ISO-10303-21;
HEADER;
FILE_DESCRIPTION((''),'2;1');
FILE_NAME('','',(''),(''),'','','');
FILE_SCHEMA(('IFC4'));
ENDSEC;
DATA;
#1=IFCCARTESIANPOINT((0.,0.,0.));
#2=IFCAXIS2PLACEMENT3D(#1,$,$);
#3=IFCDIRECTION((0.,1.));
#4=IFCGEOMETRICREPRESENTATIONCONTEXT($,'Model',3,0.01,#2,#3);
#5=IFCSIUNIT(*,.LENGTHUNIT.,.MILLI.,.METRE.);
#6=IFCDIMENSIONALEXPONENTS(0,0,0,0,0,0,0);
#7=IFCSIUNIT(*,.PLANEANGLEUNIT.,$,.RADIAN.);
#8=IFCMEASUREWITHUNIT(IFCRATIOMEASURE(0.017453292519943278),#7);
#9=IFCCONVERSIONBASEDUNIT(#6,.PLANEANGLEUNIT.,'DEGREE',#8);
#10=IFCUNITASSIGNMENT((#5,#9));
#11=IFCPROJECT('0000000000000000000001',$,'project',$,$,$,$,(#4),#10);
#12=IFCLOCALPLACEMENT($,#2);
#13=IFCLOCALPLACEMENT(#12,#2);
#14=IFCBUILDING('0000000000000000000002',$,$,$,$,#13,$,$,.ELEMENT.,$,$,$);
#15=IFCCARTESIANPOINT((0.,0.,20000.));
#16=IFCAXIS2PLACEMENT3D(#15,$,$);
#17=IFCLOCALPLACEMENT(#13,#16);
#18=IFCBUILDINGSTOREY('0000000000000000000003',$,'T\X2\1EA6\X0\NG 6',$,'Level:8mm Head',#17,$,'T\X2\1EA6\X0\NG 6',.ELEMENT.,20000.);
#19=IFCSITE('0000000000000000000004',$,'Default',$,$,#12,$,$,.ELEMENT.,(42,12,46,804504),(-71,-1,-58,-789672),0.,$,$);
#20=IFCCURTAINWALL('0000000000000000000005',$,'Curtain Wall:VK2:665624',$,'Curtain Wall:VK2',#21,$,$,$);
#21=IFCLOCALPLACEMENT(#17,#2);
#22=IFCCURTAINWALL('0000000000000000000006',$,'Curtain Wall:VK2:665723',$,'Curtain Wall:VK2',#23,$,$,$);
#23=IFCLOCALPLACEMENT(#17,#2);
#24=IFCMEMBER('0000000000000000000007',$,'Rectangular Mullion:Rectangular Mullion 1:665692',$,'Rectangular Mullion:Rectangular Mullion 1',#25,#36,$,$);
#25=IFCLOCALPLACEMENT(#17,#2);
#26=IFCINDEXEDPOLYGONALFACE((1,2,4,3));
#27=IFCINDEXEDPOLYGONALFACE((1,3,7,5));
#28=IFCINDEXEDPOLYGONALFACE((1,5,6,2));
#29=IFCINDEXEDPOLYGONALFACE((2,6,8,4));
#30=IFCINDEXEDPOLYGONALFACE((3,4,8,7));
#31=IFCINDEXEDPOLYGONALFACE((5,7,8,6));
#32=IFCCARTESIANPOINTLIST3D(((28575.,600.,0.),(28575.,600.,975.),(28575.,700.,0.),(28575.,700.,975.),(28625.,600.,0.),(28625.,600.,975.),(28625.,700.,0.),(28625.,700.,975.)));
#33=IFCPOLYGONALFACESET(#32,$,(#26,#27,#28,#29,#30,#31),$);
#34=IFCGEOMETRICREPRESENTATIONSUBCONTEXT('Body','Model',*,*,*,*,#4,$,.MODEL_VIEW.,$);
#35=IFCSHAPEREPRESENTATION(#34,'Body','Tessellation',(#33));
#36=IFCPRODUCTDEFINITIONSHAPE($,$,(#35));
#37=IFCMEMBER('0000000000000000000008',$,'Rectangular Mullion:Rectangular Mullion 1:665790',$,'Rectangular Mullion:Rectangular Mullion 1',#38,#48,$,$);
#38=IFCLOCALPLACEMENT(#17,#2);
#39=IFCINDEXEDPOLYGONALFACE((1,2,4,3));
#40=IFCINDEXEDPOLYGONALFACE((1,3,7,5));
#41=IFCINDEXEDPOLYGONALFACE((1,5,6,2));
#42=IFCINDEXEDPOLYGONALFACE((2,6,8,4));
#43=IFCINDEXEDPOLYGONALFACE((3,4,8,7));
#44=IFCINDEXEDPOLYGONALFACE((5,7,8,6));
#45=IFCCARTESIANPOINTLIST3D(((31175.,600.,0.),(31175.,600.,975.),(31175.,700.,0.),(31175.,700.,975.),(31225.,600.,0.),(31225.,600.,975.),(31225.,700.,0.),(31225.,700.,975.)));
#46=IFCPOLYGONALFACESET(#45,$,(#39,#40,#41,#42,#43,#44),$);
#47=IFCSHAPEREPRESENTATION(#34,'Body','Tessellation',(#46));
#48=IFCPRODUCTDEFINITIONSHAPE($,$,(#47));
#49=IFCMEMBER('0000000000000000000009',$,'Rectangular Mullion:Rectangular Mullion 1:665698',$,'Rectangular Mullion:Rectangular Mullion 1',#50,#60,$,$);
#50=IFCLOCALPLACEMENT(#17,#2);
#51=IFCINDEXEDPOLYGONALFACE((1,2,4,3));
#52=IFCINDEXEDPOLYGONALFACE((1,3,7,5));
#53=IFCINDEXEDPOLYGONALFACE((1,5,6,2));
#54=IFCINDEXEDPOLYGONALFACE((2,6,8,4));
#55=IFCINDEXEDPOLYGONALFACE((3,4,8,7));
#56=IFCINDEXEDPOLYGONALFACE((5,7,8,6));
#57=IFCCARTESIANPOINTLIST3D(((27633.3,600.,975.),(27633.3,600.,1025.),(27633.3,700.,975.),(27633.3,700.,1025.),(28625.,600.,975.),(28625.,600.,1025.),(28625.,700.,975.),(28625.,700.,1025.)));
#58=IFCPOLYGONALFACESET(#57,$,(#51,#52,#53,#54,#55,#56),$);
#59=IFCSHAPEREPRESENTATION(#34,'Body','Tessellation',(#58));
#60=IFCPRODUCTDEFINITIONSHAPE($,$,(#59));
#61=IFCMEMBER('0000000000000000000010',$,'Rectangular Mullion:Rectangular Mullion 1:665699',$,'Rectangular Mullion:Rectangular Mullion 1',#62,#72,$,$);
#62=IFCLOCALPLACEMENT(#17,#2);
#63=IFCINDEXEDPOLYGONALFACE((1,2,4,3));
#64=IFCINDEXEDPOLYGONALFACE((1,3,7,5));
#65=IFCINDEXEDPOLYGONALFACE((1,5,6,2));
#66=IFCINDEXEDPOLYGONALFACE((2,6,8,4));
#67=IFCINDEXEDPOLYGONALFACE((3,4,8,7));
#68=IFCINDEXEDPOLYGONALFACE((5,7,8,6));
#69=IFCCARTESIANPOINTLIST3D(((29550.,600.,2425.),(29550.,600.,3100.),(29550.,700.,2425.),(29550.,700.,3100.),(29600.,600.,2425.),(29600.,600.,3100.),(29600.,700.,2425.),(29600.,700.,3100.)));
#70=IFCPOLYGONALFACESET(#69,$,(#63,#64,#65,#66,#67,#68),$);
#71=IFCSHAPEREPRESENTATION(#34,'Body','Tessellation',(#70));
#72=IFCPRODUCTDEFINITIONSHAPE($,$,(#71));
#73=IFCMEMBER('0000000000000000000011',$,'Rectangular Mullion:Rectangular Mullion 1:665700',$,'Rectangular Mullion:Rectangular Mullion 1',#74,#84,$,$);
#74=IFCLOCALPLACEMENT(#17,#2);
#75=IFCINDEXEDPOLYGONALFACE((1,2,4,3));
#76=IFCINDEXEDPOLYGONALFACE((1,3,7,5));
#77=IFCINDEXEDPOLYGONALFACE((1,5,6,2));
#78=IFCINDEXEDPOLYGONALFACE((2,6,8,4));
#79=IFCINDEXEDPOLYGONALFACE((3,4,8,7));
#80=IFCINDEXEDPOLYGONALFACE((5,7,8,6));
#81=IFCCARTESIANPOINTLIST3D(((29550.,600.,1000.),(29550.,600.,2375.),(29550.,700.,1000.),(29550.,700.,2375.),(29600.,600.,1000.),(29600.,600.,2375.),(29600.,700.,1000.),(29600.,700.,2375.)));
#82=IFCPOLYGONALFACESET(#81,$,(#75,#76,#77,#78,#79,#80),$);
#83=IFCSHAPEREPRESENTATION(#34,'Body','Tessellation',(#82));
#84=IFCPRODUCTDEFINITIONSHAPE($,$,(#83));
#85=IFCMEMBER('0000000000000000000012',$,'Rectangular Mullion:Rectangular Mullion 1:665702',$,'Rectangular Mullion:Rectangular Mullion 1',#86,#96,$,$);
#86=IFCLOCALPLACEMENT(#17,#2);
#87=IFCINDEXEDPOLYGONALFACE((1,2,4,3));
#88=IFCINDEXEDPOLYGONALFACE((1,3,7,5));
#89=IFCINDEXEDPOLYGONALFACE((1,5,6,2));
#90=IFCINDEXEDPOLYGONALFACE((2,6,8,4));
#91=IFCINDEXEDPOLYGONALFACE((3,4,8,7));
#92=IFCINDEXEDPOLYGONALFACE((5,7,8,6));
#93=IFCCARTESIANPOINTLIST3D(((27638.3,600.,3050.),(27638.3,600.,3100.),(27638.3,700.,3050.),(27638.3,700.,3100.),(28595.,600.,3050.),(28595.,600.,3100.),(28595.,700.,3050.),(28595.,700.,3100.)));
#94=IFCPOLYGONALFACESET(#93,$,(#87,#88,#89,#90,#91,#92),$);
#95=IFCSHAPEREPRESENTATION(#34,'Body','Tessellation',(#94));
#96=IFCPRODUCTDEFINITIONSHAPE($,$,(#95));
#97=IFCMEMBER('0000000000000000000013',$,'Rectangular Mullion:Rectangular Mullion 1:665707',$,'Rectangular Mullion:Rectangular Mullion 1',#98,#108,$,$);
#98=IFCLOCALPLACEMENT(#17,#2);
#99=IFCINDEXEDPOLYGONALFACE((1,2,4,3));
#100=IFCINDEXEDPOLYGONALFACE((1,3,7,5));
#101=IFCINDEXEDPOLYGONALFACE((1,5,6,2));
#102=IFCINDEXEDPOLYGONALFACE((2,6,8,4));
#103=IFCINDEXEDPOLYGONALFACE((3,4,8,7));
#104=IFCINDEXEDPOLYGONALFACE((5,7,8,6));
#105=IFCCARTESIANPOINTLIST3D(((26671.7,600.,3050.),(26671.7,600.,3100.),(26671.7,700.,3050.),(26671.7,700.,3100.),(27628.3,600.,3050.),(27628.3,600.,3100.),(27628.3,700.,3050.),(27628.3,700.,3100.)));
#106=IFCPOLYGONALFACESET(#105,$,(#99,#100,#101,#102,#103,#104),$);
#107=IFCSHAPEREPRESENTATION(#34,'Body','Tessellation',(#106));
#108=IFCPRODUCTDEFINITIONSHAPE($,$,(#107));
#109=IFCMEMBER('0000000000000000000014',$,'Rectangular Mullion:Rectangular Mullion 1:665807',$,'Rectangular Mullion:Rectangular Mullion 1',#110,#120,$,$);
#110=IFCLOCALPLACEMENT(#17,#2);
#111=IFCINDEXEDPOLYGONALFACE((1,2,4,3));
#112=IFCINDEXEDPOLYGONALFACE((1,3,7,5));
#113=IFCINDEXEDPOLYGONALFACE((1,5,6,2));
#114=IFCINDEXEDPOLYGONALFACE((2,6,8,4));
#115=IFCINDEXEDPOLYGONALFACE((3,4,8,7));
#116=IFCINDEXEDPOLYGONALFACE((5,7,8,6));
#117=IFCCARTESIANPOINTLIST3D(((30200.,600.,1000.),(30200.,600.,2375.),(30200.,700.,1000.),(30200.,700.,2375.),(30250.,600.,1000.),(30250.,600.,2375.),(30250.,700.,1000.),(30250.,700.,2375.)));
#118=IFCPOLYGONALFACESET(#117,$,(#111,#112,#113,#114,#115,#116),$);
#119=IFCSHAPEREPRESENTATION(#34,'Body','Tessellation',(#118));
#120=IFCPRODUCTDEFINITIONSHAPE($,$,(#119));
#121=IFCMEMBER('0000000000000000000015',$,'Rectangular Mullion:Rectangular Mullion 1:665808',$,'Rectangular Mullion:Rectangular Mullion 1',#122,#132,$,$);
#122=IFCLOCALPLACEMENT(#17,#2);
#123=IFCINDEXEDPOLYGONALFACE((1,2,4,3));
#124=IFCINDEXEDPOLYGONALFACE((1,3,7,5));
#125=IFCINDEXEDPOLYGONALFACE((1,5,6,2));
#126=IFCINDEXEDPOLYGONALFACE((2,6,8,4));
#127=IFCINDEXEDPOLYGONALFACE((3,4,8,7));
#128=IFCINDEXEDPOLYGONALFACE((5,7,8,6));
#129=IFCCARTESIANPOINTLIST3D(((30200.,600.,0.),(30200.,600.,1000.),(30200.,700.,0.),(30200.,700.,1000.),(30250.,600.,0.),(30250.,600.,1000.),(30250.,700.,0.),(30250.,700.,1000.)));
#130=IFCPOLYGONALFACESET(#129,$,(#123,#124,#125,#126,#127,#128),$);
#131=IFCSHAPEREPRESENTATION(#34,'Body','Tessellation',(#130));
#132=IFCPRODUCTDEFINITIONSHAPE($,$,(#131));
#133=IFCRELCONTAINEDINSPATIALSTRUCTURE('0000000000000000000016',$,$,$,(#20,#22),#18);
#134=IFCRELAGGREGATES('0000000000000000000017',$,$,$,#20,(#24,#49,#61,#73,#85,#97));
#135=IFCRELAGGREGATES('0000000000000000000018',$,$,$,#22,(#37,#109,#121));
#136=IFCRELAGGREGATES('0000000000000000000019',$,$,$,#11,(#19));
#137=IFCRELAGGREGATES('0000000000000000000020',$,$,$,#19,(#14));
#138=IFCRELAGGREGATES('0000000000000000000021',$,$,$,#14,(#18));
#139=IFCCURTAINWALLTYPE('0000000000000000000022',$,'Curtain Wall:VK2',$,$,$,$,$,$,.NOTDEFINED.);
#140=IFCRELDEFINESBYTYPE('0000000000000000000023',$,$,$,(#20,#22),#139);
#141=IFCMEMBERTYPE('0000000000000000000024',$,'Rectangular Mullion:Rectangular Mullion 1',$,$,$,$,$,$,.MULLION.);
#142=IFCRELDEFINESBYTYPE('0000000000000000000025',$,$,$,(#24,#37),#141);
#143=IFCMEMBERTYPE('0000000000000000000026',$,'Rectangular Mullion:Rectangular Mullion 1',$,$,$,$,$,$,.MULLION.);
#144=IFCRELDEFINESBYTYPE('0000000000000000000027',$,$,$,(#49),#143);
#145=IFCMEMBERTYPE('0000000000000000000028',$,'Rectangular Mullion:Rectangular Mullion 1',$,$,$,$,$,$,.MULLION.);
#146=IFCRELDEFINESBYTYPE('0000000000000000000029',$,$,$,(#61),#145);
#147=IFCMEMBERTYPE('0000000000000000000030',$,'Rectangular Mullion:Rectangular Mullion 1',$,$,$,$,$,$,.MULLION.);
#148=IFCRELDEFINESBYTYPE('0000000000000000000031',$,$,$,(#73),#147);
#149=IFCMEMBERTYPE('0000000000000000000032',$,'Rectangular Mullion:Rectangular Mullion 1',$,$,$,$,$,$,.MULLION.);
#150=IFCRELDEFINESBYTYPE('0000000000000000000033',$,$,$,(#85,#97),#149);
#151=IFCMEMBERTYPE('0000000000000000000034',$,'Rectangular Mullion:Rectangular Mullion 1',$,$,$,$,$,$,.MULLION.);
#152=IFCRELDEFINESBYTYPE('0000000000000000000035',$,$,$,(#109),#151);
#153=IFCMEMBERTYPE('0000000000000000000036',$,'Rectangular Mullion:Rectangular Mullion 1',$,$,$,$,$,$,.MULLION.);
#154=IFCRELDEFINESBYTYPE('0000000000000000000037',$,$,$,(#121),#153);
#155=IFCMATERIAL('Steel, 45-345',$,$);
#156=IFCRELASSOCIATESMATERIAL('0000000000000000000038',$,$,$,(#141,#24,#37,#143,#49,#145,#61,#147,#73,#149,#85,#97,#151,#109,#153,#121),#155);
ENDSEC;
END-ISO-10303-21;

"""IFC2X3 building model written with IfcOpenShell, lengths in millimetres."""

from ifc_helpers import new_model, entity, si_unit, converted_unit, direction, frame, origin, origin_2d_with_axis, place, context, subcontext, project, spatial, rectangle, extrude, source, transform, mapped, material, type_object, type_shapes, element, aggregate, save


model = new_model("IFC2X3")

# Units and contexts
model_context = context("Model", 3, precision=0.01, world=origin(), true_north=direction((0.0, 1.0)))
body_context = subcontext(model_context, "Body", "Model", "MODEL_VIEW")
ifc_project = project(units=[si_unit("LENGTHUNIT", "METRE", prefix="MILLI"), converted_unit("PLANEANGLEUNIT", "DEGREE", entity("IfcRatioMeasure", 0.017453292519943278), si_unit("PLANEANGLEUNIT", "RADIAN"), dimensions=[0, 0, 0, 0, 0, 0, 0])], contexts=[model_context])

# Site, building, storey
site_placement = place(None, origin())
site = spatial("IfcSite", under=ifc_project, at=site_placement, Name="Default", CompositionType="ELEMENT", RefLatitude=(42, 12, 46, 804504), RefLongitude=(-71, -1, -58, -789672), RefElevation=0.0)
building_placement = place(site_placement, origin())
building = spatial("IfcBuilding", under=site, at=building_placement, CompositionType="ELEMENT")
storey_placement = place(building_placement, frame((0.0, 0.0, 20000.0)))
storey = spatial("IfcBuildingStorey", under=building, at=storey_placement, Name="TẦNG 6", ObjectType="Level:8mm Head", LongName="TẦNG 6", CompositionType="ELEMENT", Elevation=20000.0)

# Curtain wall
curtain_wall_type = type_object("IfcCurtainWallType", Name="Curtain Wall:VK2", PredefinedType="NOTDEFINED")
curtain_wall_1_placement = place(storey_placement, frame((0.0, 0.0, -20000.0)))
curtain_wall_1 = element("IfcCurtainWall", 1, at=curtain_wall_1_placement, inside=storey, type_object=curtain_wall_type, Name="Curtain Wall:VK2:665624", ObjectType="Curtain Wall:VK2")
ifc_material_1 = material(Name="Steel, 45-345")

# Curtain wall
curtain_wall_2_placement = place(storey_placement, frame((0.0, 0.0, -20000.0)))
curtain_wall_2 = element("IfcCurtainWall", 2, at=curtain_wall_2_placement, inside=storey, type_object=curtain_wall_type, Name="Curtain Wall:VK2:665723", ObjectType="Curtain Wall:VK2")

# Members
member_type_1 = type_object("IfcMemberType", Name="Rectangular Mullion:Rectangular Mullion 1", PredefinedType="MULLION", material=ifc_material_1)
shared_shape_1 = source(origin(), body_context, "Body", "SweptSolid", [
    extrude(rectangle(XDim=100.0, YDim=50.0, at=origin_2d_with_axis()), frame((0.0, 50.0, -975.0), z_axis=(0.0, 0.0, 1.0), x_axis=(0.0, -1.0, 0.0)), (0.0, 0.0, 1.0), 975.0),
])
type_shapes(member_type_1, [shared_shape_1])
member_1_placement = place(curtain_wall_1_placement, frame((28600.0, 700.0, 20000.0), z_axis=(0.0, 0.0, -1.0), x_axis=(1.0, 0.0, 0.0)))
member_1 = element("IfcMember", 3, at=member_1_placement, type_object=member_type_1, material=ifc_material_1, Name="Rectangular Mullion:Rectangular Mullion 1:665692", ObjectType="Rectangular Mullion:Rectangular Mullion 1", context=body_context, shape_type="MappedRepresentation", body=[
    mapped(shared_shape_1, transform((0.0, 0.0, 0.0), scale=1.0)),
])
member_2_placement = place(curtain_wall_2_placement, frame((31200.0, 700.0, 20000.0), z_axis=(0.0, 0.0, -1.0), x_axis=(1.0, 0.0, 0.0)))
member_2 = element("IfcMember", 4, at=member_2_placement, type_object=member_type_1, material=ifc_material_1, Name="Rectangular Mullion:Rectangular Mullion 1:665790", ObjectType="Rectangular Mullion:Rectangular Mullion 1", context=body_context, shape_type="MappedRepresentation", body=[
    mapped(shared_shape_1, transform((0.0, 0.0, 0.0), scale=1.0)),
])
member_type_2 = type_object("IfcMemberType", Name="Rectangular Mullion:Rectangular Mullion 1", PredefinedType="MULLION", material=ifc_material_1)
shared_shape_2 = source(origin(), body_context, "Body", "SweptSolid", [
    extrude(rectangle(XDim=100.0, YDim=50.0, at=origin_2d_with_axis()), frame((0.0, 50.0, -991.7), z_axis=(0.0, 0.0, 1.0), x_axis=(0.0, -1.0, 0.0)), (0.0, 0.0, 1.0), 991.7),
])
type_shapes(member_type_2, [shared_shape_2])
member_3_placement = place(curtain_wall_1_placement, frame((28625.0, 700.0, 21000.0), z_axis=(1.0, 0.0, 0.0), x_axis=(0.0, 0.0, 1.0)))
member_3 = element("IfcMember", 5, at=member_3_placement, type_object=member_type_2, material=ifc_material_1, Name="Rectangular Mullion:Rectangular Mullion 1:665698", ObjectType="Rectangular Mullion:Rectangular Mullion 1", context=body_context, shape_type="MappedRepresentation", body=[
    mapped(shared_shape_2, transform((0.0, 0.0, 0.0), scale=1.0)),
])
member_type_3 = type_object("IfcMemberType", Name="Rectangular Mullion:Rectangular Mullion 1", PredefinedType="MULLION", material=ifc_material_1)
shared_shape_3 = source(origin(), body_context, "Body", "SweptSolid", [
    extrude(rectangle(XDim=100.0, YDim=50.0, at=origin_2d_with_axis()), frame((-25.0, 50.0, -675.0), z_axis=(0.0, 0.0, 1.0), x_axis=(0.0, -1.0, 0.0)), (0.0, 0.0, 1.0), 675.0),
])
type_shapes(member_type_3, [shared_shape_3])
member_4_placement = place(curtain_wall_1_placement, frame((29600.0, 700.0, 22425.0), z_axis=(0.0, 0.0, -1.0), x_axis=(1.0, 0.0, 0.0)))
member_4 = element("IfcMember", 6, at=member_4_placement, type_object=member_type_3, material=ifc_material_1, Name="Rectangular Mullion:Rectangular Mullion 1:665699", ObjectType="Rectangular Mullion:Rectangular Mullion 1", context=body_context, shape_type="MappedRepresentation", body=[
    mapped(shared_shape_3, transform((0.0, 0.0, 0.0), scale=1.0)),
])
member_type_4 = type_object("IfcMemberType", Name="Rectangular Mullion:Rectangular Mullion 1", PredefinedType="MULLION", material=ifc_material_1)
shared_shape_4 = source(origin(), body_context, "Body", "SweptSolid", [
    extrude(rectangle(XDim=100.0, YDim=50.0, at=origin_2d_with_axis()), frame((-25.0, 50.0, -1375.0), z_axis=(0.0, 0.0, 1.0), x_axis=(0.0, -1.0, 0.0)), (0.0, 0.0, 1.0), 1375.0),
])
type_shapes(member_type_4, [shared_shape_4])
member_5_placement = place(curtain_wall_1_placement, frame((29600.0, 700.0, 21000.0), z_axis=(0.0, 0.0, -1.0), x_axis=(1.0, 0.0, 0.0)))
member_5 = element("IfcMember", 7, at=member_5_placement, type_object=member_type_4, material=ifc_material_1, Name="Rectangular Mullion:Rectangular Mullion 1:665700", ObjectType="Rectangular Mullion:Rectangular Mullion 1", context=body_context, shape_type="MappedRepresentation", body=[
    mapped(shared_shape_4, transform((0.0, 0.0, 0.0), scale=1.0)),
])
member_type_5 = type_object("IfcMemberType", Name="Rectangular Mullion:Rectangular Mullion 1", PredefinedType="MULLION", material=ifc_material_1)
shared_shape_5 = source(origin(), body_context, "Body", "SweptSolid", [
    extrude(rectangle(XDim=100.0, YDim=50.0, at=origin_2d_with_axis()), frame((-25.0, 50.0, -956.7), z_axis=(0.0, 0.0, 1.0), x_axis=(0.0, -1.0, 0.0)), (0.0, 0.0, 1.0), 956.7),
])
type_shapes(member_type_5, [shared_shape_5])
member_6_placement = place(curtain_wall_1_placement, frame((28595.0, 700.0, 23100.0), z_axis=(1.0, 0.0, 0.0), x_axis=(0.0, 0.0, 1.0)))
member_6 = element("IfcMember", 8, at=member_6_placement, type_object=member_type_5, material=ifc_material_1, Name="Rectangular Mullion:Rectangular Mullion 1:665702", ObjectType="Rectangular Mullion:Rectangular Mullion 1", context=body_context, shape_type="MappedRepresentation", body=[
    mapped(shared_shape_5, transform((0.0, 0.0, 0.0), scale=1.0)),
])
member_7_placement = place(curtain_wall_1_placement, frame((27628.3, 700.0, 23100.0), z_axis=(1.0, 0.0, 0.0), x_axis=(0.0, 0.0, 1.0)))
member_7 = element("IfcMember", 9, at=member_7_placement, type_object=member_type_5, material=ifc_material_1, Name="Rectangular Mullion:Rectangular Mullion 1:665707", ObjectType="Rectangular Mullion:Rectangular Mullion 1", context=body_context, shape_type="MappedRepresentation", body=[
    mapped(shared_shape_5, transform((0.0, 0.0, 0.0), scale=1.0)),
])
member_type_6 = type_object("IfcMemberType", Name="Rectangular Mullion:Rectangular Mullion 1", PredefinedType="MULLION", material=ifc_material_1)
shared_shape_6 = source(origin(), body_context, "Body", "SweptSolid", [
    extrude(rectangle(XDim=100.0, YDim=50.0, at=origin_2d_with_axis()), frame((-25.0, 50.0, -1375.0), z_axis=(0.0, 0.0, 1.0), x_axis=(0.0, -1.0, 0.0)), (0.0, 0.0, 1.0), 1375.0),
])
type_shapes(member_type_6, [shared_shape_6])
member_8_placement = place(curtain_wall_2_placement, frame((30200.0, 700.0, 22375.0), z_axis=(0.0, 0.0, 1.0), x_axis=(-1.0, 0.0, 0.0)))
member_8 = element("IfcMember", 10, at=member_8_placement, type_object=member_type_6, material=ifc_material_1, Name="Rectangular Mullion:Rectangular Mullion 1:665807", ObjectType="Rectangular Mullion:Rectangular Mullion 1", context=body_context, shape_type="MappedRepresentation", body=[
    mapped(shared_shape_6, transform((0.0, 0.0, 0.0), scale=1.0)),
])
member_type_7 = type_object("IfcMemberType", Name="Rectangular Mullion:Rectangular Mullion 1", PredefinedType="MULLION", material=ifc_material_1)
shared_shape_7 = source(origin(), body_context, "Body", "SweptSolid", [
    extrude(rectangle(XDim=100.0, YDim=50.0, at=origin_2d_with_axis()), frame((-25.0, 50.0, -1000.0), z_axis=(0.0, 0.0, 1.0), x_axis=(0.0, -1.0, 0.0)), (0.0, 0.0, 1.0), 1000.0),
])
type_shapes(member_type_7, [shared_shape_7])
member_9_placement = place(curtain_wall_2_placement, frame((30200.0, 700.0, 21000.0), z_axis=(0.0, 0.0, 1.0), x_axis=(-1.0, 0.0, 0.0)))
member_9 = element("IfcMember", 11, at=member_9_placement, type_object=member_type_7, material=ifc_material_1, Name="Rectangular Mullion:Rectangular Mullion 1:665808", ObjectType="Rectangular Mullion:Rectangular Mullion 1", context=body_context, shape_type="MappedRepresentation", body=[
    mapped(shared_shape_7, transform((0.0, 0.0, 0.0), scale=1.0)),
])

aggregate(curtain_wall_1, [member_1, member_3, member_4, member_5, member_6, member_7])
aggregate(curtain_wall_2, [member_2, member_8, member_9])

save(model, "model.ifc")
